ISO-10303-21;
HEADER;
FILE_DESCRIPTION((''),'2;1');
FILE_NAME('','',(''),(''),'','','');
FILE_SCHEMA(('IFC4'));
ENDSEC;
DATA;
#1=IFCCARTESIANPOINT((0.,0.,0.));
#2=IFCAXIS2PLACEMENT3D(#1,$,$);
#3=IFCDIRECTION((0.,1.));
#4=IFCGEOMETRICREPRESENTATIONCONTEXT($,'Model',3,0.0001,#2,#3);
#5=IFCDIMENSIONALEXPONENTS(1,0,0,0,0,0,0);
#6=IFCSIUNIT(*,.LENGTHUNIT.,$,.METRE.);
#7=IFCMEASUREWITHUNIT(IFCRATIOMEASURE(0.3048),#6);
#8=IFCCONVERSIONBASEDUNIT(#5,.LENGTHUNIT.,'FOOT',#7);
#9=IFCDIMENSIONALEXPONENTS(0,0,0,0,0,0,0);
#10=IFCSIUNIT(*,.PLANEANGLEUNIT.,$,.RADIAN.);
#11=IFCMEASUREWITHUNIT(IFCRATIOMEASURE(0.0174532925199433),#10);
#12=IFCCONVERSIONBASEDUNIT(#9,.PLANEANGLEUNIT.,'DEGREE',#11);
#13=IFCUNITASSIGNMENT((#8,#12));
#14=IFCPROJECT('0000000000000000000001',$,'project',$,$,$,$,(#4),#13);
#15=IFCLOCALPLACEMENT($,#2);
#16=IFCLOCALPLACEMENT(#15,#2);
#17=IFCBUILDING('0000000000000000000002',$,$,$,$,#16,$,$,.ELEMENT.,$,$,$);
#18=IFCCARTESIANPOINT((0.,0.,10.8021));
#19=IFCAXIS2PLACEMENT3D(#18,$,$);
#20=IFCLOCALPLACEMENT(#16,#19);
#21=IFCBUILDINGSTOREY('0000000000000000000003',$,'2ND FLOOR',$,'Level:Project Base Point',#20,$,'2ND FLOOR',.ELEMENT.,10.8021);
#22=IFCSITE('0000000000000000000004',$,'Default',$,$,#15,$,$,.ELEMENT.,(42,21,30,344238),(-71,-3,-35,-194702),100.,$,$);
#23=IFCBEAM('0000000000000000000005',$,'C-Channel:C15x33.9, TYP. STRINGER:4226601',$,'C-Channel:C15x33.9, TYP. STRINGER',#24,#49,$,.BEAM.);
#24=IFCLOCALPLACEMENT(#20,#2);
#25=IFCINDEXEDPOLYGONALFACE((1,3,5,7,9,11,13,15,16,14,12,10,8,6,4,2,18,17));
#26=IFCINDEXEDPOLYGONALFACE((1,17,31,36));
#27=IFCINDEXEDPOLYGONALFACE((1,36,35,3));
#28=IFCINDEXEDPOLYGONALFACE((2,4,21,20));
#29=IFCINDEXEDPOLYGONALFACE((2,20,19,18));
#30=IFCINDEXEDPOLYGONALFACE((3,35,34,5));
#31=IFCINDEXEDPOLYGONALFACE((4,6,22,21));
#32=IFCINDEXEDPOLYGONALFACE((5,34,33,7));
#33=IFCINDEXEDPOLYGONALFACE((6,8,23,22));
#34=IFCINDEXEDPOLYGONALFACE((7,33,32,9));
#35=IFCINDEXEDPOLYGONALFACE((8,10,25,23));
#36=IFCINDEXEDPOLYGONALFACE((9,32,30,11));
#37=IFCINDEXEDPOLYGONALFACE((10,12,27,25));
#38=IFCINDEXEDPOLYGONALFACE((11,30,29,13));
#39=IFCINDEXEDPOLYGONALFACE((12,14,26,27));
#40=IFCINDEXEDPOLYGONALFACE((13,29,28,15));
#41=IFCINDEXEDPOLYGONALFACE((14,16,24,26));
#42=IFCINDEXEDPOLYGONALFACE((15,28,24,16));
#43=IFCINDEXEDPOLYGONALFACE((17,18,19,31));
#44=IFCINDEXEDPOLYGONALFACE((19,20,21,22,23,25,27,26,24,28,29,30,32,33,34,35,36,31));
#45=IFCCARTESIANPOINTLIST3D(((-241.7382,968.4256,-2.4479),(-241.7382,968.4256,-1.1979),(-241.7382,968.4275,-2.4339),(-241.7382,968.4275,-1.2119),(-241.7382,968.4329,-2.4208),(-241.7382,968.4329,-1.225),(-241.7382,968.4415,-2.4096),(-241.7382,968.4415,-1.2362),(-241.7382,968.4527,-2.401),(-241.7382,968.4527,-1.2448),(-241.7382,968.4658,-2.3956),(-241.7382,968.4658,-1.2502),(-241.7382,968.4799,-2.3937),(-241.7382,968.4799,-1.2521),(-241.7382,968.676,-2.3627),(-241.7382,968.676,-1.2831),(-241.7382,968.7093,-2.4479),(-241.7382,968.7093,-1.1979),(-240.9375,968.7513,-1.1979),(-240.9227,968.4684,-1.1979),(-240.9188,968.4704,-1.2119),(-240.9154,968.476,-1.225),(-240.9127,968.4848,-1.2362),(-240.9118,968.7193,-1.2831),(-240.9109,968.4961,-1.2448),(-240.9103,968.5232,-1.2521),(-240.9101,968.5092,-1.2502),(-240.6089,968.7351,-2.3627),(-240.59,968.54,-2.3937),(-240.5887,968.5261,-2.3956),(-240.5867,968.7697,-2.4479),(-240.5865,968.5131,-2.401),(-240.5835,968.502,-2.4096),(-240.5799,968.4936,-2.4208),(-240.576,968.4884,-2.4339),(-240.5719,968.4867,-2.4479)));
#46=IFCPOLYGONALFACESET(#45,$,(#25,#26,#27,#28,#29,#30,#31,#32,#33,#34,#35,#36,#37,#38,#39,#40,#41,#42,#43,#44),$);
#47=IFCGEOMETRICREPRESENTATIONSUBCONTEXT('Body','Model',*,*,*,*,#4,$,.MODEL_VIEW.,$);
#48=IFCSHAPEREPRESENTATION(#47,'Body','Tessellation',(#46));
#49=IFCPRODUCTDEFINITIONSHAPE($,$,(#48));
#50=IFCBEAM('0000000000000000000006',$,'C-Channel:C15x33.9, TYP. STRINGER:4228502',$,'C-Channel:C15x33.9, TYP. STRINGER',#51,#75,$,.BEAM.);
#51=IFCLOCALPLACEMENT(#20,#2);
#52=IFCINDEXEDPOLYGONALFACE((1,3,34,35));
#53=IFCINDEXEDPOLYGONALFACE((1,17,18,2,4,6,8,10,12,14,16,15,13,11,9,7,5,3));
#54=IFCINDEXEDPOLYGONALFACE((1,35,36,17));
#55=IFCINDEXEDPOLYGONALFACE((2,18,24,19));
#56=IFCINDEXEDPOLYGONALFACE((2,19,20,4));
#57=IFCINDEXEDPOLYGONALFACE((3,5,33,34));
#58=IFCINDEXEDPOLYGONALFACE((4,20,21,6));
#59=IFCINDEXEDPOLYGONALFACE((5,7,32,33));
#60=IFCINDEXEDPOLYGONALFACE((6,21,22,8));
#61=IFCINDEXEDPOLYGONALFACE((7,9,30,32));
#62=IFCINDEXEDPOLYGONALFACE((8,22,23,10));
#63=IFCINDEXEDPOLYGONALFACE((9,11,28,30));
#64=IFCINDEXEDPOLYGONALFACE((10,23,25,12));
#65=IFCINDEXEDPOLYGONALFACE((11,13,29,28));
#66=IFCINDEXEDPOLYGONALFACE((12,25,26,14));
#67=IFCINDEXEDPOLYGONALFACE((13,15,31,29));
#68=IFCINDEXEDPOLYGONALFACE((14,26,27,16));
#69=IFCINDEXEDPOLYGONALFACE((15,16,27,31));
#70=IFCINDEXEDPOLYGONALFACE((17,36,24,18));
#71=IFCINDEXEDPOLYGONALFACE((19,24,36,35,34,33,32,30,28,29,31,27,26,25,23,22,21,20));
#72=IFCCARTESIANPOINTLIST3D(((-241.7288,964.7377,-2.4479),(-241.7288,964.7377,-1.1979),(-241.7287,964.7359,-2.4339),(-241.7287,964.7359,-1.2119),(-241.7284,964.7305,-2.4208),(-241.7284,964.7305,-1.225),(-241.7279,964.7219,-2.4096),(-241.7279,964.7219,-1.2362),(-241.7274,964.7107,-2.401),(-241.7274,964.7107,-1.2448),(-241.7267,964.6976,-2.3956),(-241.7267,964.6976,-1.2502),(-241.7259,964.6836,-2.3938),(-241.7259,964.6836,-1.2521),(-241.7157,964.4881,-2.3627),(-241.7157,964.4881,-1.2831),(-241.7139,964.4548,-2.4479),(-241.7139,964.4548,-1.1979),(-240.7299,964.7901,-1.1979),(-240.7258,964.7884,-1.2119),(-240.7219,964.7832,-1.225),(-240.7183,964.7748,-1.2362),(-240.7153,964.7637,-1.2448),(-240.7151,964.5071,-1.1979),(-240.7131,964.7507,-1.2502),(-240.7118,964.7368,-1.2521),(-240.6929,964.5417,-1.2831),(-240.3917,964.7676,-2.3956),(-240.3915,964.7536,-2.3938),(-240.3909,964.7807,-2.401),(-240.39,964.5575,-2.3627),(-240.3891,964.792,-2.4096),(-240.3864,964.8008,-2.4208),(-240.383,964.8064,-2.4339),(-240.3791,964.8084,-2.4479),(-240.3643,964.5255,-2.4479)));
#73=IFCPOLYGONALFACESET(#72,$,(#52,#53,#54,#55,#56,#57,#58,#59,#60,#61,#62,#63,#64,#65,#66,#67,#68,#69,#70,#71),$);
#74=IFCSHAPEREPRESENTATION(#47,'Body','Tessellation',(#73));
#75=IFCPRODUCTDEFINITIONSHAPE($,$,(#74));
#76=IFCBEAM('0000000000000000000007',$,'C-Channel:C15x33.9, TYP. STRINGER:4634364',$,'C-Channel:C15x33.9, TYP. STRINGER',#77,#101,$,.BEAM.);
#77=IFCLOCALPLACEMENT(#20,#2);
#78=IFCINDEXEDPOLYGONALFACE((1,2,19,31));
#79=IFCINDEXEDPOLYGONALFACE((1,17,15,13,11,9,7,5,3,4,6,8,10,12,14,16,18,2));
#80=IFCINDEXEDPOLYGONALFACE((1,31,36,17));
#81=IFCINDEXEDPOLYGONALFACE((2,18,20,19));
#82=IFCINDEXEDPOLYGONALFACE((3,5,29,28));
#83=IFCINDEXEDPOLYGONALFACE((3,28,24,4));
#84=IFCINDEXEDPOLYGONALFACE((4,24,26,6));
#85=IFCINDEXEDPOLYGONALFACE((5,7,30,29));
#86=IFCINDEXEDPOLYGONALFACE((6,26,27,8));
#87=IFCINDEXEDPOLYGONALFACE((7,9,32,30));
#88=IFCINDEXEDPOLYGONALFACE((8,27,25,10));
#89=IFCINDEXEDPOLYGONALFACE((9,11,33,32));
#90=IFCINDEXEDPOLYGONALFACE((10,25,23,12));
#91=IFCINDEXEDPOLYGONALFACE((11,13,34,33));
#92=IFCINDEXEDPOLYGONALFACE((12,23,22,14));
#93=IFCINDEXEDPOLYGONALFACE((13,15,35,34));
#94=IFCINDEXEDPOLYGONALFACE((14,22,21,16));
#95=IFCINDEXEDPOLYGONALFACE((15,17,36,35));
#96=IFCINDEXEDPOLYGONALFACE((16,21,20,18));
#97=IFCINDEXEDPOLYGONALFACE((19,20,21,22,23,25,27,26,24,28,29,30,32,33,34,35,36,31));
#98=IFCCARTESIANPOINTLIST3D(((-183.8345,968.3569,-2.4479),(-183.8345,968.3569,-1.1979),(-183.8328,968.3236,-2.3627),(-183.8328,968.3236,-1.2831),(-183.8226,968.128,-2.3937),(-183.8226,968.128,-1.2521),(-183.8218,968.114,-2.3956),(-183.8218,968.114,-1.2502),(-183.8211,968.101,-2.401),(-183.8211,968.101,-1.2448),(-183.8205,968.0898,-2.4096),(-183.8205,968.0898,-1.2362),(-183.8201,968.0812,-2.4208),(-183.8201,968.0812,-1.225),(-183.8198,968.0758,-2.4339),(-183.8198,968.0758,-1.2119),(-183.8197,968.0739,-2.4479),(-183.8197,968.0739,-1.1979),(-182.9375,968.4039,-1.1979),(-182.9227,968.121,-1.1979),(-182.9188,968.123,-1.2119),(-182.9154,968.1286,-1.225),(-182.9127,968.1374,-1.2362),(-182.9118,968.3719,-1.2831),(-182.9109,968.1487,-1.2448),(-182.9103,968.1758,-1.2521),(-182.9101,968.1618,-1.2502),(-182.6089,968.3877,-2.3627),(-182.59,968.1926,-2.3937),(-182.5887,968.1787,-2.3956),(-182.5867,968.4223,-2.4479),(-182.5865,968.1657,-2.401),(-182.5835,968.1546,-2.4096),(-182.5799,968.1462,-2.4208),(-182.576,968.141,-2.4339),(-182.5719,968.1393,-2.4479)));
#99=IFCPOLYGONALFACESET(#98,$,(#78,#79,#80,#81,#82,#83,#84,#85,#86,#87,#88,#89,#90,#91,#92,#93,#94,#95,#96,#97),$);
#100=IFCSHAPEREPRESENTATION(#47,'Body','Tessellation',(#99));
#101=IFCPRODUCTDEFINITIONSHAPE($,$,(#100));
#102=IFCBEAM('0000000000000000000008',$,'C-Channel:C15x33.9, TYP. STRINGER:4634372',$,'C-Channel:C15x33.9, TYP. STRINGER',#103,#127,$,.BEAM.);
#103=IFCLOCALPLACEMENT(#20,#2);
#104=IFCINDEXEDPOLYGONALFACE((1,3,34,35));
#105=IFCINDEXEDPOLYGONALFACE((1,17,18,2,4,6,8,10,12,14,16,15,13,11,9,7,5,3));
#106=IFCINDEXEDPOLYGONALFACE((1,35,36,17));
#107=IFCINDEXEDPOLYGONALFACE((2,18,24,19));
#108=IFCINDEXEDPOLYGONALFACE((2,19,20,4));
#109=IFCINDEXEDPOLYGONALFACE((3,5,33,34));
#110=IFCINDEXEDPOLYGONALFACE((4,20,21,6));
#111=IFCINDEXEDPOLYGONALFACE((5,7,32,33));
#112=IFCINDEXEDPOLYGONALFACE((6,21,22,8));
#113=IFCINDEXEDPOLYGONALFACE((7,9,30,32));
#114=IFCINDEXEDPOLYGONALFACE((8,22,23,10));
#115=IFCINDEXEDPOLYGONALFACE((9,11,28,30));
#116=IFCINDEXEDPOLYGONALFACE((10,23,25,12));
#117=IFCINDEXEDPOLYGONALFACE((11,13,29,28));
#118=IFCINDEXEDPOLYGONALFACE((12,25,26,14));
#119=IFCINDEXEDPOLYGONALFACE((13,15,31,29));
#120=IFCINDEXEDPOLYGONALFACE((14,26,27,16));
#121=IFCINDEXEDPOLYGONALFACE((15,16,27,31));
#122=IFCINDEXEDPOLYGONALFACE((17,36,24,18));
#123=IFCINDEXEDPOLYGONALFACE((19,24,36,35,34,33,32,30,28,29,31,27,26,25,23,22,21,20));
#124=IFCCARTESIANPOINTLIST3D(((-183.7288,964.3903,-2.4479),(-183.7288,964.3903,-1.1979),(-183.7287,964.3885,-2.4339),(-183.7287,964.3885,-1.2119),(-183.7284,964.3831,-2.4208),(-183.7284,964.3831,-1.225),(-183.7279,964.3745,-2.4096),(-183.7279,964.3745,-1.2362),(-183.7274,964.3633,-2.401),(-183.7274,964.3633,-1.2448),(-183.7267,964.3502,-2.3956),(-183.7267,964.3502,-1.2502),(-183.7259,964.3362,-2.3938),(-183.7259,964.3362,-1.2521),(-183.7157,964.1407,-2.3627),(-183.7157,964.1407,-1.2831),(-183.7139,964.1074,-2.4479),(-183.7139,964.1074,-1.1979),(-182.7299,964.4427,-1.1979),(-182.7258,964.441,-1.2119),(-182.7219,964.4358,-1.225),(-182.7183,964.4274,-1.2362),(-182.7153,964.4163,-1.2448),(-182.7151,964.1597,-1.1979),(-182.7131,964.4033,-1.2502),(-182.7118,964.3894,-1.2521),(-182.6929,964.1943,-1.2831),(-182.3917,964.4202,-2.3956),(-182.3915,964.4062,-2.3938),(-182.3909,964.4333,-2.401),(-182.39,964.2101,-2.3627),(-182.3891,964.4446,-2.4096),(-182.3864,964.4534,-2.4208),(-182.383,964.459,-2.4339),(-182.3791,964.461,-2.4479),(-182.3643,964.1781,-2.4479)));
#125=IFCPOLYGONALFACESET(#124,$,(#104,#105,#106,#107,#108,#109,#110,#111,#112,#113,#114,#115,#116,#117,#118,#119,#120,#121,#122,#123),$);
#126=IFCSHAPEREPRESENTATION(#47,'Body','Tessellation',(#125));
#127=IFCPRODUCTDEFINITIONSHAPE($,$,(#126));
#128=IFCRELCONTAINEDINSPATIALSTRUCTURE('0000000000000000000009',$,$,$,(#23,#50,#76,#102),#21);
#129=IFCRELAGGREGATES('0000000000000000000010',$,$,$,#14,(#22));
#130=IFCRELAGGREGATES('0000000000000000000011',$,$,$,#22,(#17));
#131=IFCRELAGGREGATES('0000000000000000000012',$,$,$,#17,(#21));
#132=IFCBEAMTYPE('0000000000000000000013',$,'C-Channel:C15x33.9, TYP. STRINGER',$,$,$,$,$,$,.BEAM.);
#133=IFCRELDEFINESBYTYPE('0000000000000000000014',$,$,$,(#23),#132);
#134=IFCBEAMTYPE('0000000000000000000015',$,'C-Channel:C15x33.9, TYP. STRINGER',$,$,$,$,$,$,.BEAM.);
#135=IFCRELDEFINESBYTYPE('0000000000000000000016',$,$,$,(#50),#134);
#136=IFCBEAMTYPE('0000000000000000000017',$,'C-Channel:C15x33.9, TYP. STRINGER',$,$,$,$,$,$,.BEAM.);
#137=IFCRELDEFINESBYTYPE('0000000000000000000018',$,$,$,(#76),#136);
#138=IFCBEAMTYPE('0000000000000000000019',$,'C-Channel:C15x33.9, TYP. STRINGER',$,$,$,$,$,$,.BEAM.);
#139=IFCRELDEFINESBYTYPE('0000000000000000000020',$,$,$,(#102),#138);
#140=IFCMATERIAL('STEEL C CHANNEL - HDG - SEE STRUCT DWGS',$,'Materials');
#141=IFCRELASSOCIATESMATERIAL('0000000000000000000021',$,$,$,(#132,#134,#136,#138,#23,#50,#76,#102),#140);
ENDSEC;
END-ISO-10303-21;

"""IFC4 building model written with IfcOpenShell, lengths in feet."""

from ifc_helpers import new_model, entity, si_unit, converted_unit, direction, frame, frame_2d, origin, place, context, subcontext, project, spatial, polyline, circle_curve, parameter, trimmed, segment, composite_curve, outline, extrude, clip, halfspace, source, transform, mapped, material, material_profile, profile_set, profile_usage, type_object, type_shapes, element, save


model = new_model("IFC4")

# Units and contexts
model_context = context("Model", 3, precision=0.0001, world=origin(), true_north=direction((0.0, 1.0)))
body_context = subcontext(model_context, "Body", "Model", "MODEL_VIEW")
ifc_project = project(units=[converted_unit("LENGTHUNIT", "FOOT", entity("IfcRatioMeasure", 0.3048), si_unit("LENGTHUNIT", "METRE"), dimensions=[1, 0, 0, 0, 0, 0, 0]), converted_unit("PLANEANGLEUNIT", "DEGREE", entity("IfcRatioMeasure", 0.0174532925199433), si_unit("PLANEANGLEUNIT", "RADIAN"), dimensions=[0, 0, 0, 0, 0, 0, 0])], contexts=[model_context])

# Site, building, storey
site_placement = place(None, origin())
site = spatial("IfcSite", under=ifc_project, at=site_placement, Name="Default", CompositionType="ELEMENT", RefLatitude=(42, 21, 30, 344238), RefLongitude=(-71, -3, -35, -194702), RefElevation=100.0)
building_placement = place(site_placement, origin())
building = spatial("IfcBuilding", under=site, at=building_placement, CompositionType="ELEMENT")
storey_placement = place(building_placement, frame((0.0, 0.0, 10.8021)))
storey = spatial("IfcBuildingStorey", under=building, at=storey_placement, Name="2ND FLOOR", ObjectType="Level:Project Base Point", LongName="2ND FLOOR", CompositionType="ELEMENT", Elevation=10.8021)

# Beams
ifc_material_1 = material(Name="STEEL C CHANNEL - HDG - SEE STRUCT DWGS", Category="Materials")
ifc_material_profile_1 = material_profile(ifc_material_1, outline(composite_curve([segment(polyline([(-0.625, -0.1365), (0.625, -0.1365)]), True, "CONTINUOUS"), segment(polyline([(0.625, -0.1365), (0.625, 0.1469)]), True, "CONTINUOUS"), segment(trimmed(circle_curve(frame_2d((0.625, 0.0927), x_axis=(0.0, 1.0)), 0.0542), [parameter(0.0)], [parameter(90.0)], True, "PARAMETER"), True, "CONTINUOUS"), segment(polyline([(0.5708, 0.0927), (0.5398, -0.1031)]), True, "CONTINUOUS"), segment(polyline([(0.5398, -0.1031), (-0.5398, -0.1031)]), True, "CONTINUOUS"), segment(polyline([(-0.5398, -0.1031), (-0.5708, 0.0927)]), True, "CONTINUOUS"), segment(trimmed(circle_curve(frame_2d((-0.625, 0.0927), x_axis=(1.0, 0.0)), 0.0542), [parameter(0.0)], [parameter(90.0)], True, "PARAMETER"), True, "CONTINUOUS"), segment(polyline([(-0.625, 0.1469), (-0.625, -0.1365)]), True, "CONTINUOUS")], self_intersect=False)), Name="C15x33.9, TYP. STRINGER")
ifc_profile_set_1 = profile_set([ifc_material_profile_1], Name="C15x33.9, TYP. STRINGER")
ifc_profile_usage_1 = profile_usage(ifc_profile_set_1, cardinal=8)
beam_type_1 = type_object("IfcBeamType", Name="C-Channel:C15x33.9, TYP. STRINGER", PredefinedType="BEAM", material=ifc_profile_set_1)
shared_shape_1 = source(origin(), body_context, "Body", "Clipping", [
    clip(clip(extrude(outline(composite_curve([segment(polyline([(-0.625, -0.1365), (0.625, -0.1365)]), True, "CONTINUOUS"), segment(polyline([(0.625, -0.1365), (0.625, 0.1469)]), True, "CONTINUOUS"), segment(trimmed(circle_curve(frame_2d((0.625, 0.0927), x_axis=(0.0, 1.0)), 0.0542), [parameter(0.0)], [parameter(90.0)], True, "PARAMETER"), True, "CONTINUOUS"), segment(polyline([(0.5708, 0.0927), (0.5398, -0.1031)]), True, "CONTINUOUS"), segment(polyline([(0.5398, -0.1031), (-0.5398, -0.1031)]), True, "CONTINUOUS"), segment(polyline([(-0.5398, -0.1031), (-0.5708, 0.0927)]), True, "CONTINUOUS"), segment(trimmed(circle_curve(frame_2d((-0.625, 0.0927), x_axis=(1.0, 0.0)), 0.0542), [parameter(0.0)], [parameter(90.0)], True, "PARAMETER"), True, "CONTINUOUS"), segment(polyline([(-0.625, 0.1469), (-0.625, -0.1365)]), True, "CONTINUOUS")], self_intersect=False)), frame((-241.7458, 968.5723, 8.9792), z_axis=(0.99863, 0.052336, 0.0), x_axis=(0.0, 0.0, 1.0)), (0.0, 0.0, 1.0), 1.1678), halfspace(frame((-241.7382, 933.7419, 4.0), z_axis=(-1.0, 0.0, 0.0), x_axis=(0.0, -1.0, 0.0)), False)), halfspace(frame((-240.0345, 965.5387, 6.993), z_axis=(0.961402, 0.050385, 0.270495), x_axis=(0.270124, 0.014157, -0.962721)), False)),
])
type_shapes(beam_type_1, [shared_shape_1])
beam_1_placement = place(storey_placement, frame((0.0, 0.0, -10.8021)))
element("IfcBeam", 1, at=beam_1_placement, inside=storey, type_object=beam_type_1, material=ifc_profile_usage_1, Name="C-Channel:C15x33.9, TYP. STRINGER:4226601", ObjectType="C-Channel:C15x33.9, TYP. STRINGER", PredefinedType="BEAM", context=body_context, shape_type="MappedRepresentation", body=[
    mapped(shared_shape_1, transform((0.0, 0.0, 0.0), scale=1.0)),
])
ifc_profile_usage_2 = profile_usage(ifc_profile_set_1, cardinal=8)
beam_type_2 = type_object("IfcBeamType", Name="C-Channel:C15x33.9, TYP. STRINGER", PredefinedType="BEAM", material=ifc_profile_set_1)
shared_shape_2 = source(origin(), body_context, "Body", "Clipping", [
    clip(extrude(outline(composite_curve([segment(polyline([(-0.1469, -0.625), (0.1365, -0.625)]), True, "CONTINUOUS"), segment(polyline([(0.1365, -0.625), (0.1365, 0.625)]), True, "CONTINUOUS"), segment(polyline([(0.1365, 0.625), (-0.1469, 0.625)]), True, "CONTINUOUS"), segment(trimmed(circle_curve(frame_2d((-0.0927, 0.625), x_axis=(-1.0, 0.0)), 0.0542), [parameter(0.0)], [parameter(90.0)], True, "PARAMETER"), True, "CONTINUOUS"), segment(polyline([(-0.0927, 0.5708), (0.1031, 0.5398)]), True, "CONTINUOUS"), segment(polyline([(0.1031, 0.5398), (0.1031, -0.5398)]), True, "CONTINUOUS"), segment(polyline([(0.1031, -0.5398), (-0.0927, -0.5708)]), True, "CONTINUOUS"), segment(trimmed(circle_curve(frame_2d((-0.0927, -0.625), x_axis=(0.0, 1.0)), 0.0542), [parameter(0.0)], [parameter(90.0)], True, "PARAMETER"), True, "CONTINUOUS")], self_intersect=False)), frame((-241.7211, 964.591, 8.9792), z_axis=(0.99863, 0.052336, 0.0), x_axis=(0.052336, -0.99863, 0.0)), (0.0, 0.0, 1.0), 1.3515), halfspace(frame((-240.0345, 965.5387, 6.993), z_axis=(0.961402, 0.050385, 0.270495), x_axis=(0.270124, 0.014157, -0.962721)), False)),
])
type_shapes(beam_type_2, [shared_shape_2])
beam_2_placement = place(storey_placement, frame((0.0, 0.0, -10.8021)))
element("IfcBeam", 2, at=beam_2_placement, inside=storey, type_object=beam_type_2, material=ifc_profile_usage_2, Name="C-Channel:C15x33.9, TYP. STRINGER:4228502", ObjectType="C-Channel:C15x33.9, TYP. STRINGER", PredefinedType="BEAM", context=body_context, shape_type="MappedRepresentation", body=[
    mapped(shared_shape_2, transform((0.0, 0.0, 0.0), scale=1.0)),
])
ifc_profile_usage_3 = profile_usage(ifc_profile_set_1, cardinal=8)
beam_type_3 = type_object("IfcBeamType", Name="C-Channel:C15x33.9, TYP. STRINGER", PredefinedType="BEAM", material=ifc_profile_set_1)
shared_shape_3 = source(origin(), body_context, "Body", "Clipping", [
    clip(extrude(outline(composite_curve([segment(polyline([(-0.625, -0.1365), (0.625, -0.1365)]), True, "CONTINUOUS"), segment(polyline([(0.625, -0.1365), (0.625, 0.1469)]), True, "CONTINUOUS"), segment(trimmed(circle_curve(frame_2d((0.625, 0.0927), x_axis=(0.0, 1.0)), 0.0542), [parameter(0.0)], [parameter(90.0)], True, "PARAMETER"), True, "CONTINUOUS"), segment(polyline([(0.5708, 0.0927), (0.5398, -0.1031)]), True, "CONTINUOUS"), segment(polyline([(0.5398, -0.1031), (-0.5398, -0.1031)]), True, "CONTINUOUS"), segment(polyline([(-0.5398, -0.1031), (-0.5708, 0.0927)]), True, "CONTINUOUS"), segment(trimmed(circle_curve(frame_2d((-0.625, 0.0927), x_axis=(1.0, 0.0)), 0.0542), [parameter(0.0)], [parameter(90.0)], True, "PARAMETER"), True, "CONTINUOUS"), segment(polyline([(-0.625, 0.1469), (-0.625, -0.1365)]), True, "CONTINUOUS")], self_intersect=False)), frame((-183.8274, 968.2206, 8.9792), z_axis=(0.99863, 0.052336, 0.0), x_axis=(0.0, 0.0, 1.0)), (0.0, 0.0, 1.0), 1.2495), halfspace(frame((-182.0345, 965.1913, 6.993), z_axis=(0.961402, 0.050385, 0.270495), x_axis=(0.270124, 0.014157, -0.962721)), False)),
])
type_shapes(beam_type_3, [shared_shape_3])
beam_3_placement = place(storey_placement, frame((0.0, 0.0, -10.8021)))
element("IfcBeam", 3, at=beam_3_placement, inside=storey, type_object=beam_type_3, material=ifc_profile_usage_3, Name="C-Channel:C15x33.9, TYP. STRINGER:4634364", ObjectType="C-Channel:C15x33.9, TYP. STRINGER", PredefinedType="BEAM", context=body_context, shape_type="MappedRepresentation", body=[
    mapped(shared_shape_3, transform((0.0, 0.0, 0.0), scale=1.0)),
])
ifc_profile_usage_4 = profile_usage(ifc_profile_set_1, cardinal=8)
beam_type_4 = type_object("IfcBeamType", Name="C-Channel:C15x33.9, TYP. STRINGER", PredefinedType="BEAM", material=ifc_profile_set_1)
shared_shape_4 = source(origin(), body_context, "Body", "Clipping", [
    clip(extrude(outline(composite_curve([segment(polyline([(-0.1469, -0.625), (0.1365, -0.625)]), True, "CONTINUOUS"), segment(polyline([(0.1365, -0.625), (0.1365, 0.625)]), True, "CONTINUOUS"), segment(polyline([(0.1365, 0.625), (-0.1469, 0.625)]), True, "CONTINUOUS"), segment(trimmed(circle_curve(frame_2d((-0.0927, 0.625), x_axis=(-1.0, 0.0)), 0.0542), [parameter(0.0)], [parameter(90.0)], True, "PARAMETER"), True, "CONTINUOUS"), segment(polyline([(-0.0927, 0.5708), (0.1031, 0.5398)]), True, "CONTINUOUS"), segment(polyline([(0.1031, 0.5398), (0.1031, -0.5398)]), True, "CONTINUOUS"), segment(polyline([(0.1031, -0.5398), (-0.0927, -0.5708)]), True, "CONTINUOUS"), segment(trimmed(circle_curve(frame_2d((-0.0927, -0.625), x_axis=(0.0, 1.0)), 0.0542), [parameter(0.0)], [parameter(90.0)], True, "PARAMETER"), True, "CONTINUOUS")], self_intersect=False)), frame((-183.7211, 964.2436, 8.9792), z_axis=(0.99863, 0.052336, 0.0), x_axis=(0.052336, -0.99863, 0.0)), (0.0, 0.0, 1.0), 1.3515), halfspace(frame((-182.0345, 965.1913, 6.993), z_axis=(0.961402, 0.050385, 0.270495), x_axis=(0.270124, 0.014157, -0.962721)), False)),
])
type_shapes(beam_type_4, [shared_shape_4])
beam_4_placement = place(storey_placement, frame((0.0, 0.0, -10.8021)))
element("IfcBeam", 4, at=beam_4_placement, inside=storey, type_object=beam_type_4, material=ifc_profile_usage_4, Name="C-Channel:C15x33.9, TYP. STRINGER:4634372", ObjectType="C-Channel:C15x33.9, TYP. STRINGER", PredefinedType="BEAM", context=body_context, shape_type="MappedRepresentation", body=[
    mapped(shared_shape_4, transform((0.0, 0.0, 0.0), scale=1.0)),
])

save(model, "model.ifc")
